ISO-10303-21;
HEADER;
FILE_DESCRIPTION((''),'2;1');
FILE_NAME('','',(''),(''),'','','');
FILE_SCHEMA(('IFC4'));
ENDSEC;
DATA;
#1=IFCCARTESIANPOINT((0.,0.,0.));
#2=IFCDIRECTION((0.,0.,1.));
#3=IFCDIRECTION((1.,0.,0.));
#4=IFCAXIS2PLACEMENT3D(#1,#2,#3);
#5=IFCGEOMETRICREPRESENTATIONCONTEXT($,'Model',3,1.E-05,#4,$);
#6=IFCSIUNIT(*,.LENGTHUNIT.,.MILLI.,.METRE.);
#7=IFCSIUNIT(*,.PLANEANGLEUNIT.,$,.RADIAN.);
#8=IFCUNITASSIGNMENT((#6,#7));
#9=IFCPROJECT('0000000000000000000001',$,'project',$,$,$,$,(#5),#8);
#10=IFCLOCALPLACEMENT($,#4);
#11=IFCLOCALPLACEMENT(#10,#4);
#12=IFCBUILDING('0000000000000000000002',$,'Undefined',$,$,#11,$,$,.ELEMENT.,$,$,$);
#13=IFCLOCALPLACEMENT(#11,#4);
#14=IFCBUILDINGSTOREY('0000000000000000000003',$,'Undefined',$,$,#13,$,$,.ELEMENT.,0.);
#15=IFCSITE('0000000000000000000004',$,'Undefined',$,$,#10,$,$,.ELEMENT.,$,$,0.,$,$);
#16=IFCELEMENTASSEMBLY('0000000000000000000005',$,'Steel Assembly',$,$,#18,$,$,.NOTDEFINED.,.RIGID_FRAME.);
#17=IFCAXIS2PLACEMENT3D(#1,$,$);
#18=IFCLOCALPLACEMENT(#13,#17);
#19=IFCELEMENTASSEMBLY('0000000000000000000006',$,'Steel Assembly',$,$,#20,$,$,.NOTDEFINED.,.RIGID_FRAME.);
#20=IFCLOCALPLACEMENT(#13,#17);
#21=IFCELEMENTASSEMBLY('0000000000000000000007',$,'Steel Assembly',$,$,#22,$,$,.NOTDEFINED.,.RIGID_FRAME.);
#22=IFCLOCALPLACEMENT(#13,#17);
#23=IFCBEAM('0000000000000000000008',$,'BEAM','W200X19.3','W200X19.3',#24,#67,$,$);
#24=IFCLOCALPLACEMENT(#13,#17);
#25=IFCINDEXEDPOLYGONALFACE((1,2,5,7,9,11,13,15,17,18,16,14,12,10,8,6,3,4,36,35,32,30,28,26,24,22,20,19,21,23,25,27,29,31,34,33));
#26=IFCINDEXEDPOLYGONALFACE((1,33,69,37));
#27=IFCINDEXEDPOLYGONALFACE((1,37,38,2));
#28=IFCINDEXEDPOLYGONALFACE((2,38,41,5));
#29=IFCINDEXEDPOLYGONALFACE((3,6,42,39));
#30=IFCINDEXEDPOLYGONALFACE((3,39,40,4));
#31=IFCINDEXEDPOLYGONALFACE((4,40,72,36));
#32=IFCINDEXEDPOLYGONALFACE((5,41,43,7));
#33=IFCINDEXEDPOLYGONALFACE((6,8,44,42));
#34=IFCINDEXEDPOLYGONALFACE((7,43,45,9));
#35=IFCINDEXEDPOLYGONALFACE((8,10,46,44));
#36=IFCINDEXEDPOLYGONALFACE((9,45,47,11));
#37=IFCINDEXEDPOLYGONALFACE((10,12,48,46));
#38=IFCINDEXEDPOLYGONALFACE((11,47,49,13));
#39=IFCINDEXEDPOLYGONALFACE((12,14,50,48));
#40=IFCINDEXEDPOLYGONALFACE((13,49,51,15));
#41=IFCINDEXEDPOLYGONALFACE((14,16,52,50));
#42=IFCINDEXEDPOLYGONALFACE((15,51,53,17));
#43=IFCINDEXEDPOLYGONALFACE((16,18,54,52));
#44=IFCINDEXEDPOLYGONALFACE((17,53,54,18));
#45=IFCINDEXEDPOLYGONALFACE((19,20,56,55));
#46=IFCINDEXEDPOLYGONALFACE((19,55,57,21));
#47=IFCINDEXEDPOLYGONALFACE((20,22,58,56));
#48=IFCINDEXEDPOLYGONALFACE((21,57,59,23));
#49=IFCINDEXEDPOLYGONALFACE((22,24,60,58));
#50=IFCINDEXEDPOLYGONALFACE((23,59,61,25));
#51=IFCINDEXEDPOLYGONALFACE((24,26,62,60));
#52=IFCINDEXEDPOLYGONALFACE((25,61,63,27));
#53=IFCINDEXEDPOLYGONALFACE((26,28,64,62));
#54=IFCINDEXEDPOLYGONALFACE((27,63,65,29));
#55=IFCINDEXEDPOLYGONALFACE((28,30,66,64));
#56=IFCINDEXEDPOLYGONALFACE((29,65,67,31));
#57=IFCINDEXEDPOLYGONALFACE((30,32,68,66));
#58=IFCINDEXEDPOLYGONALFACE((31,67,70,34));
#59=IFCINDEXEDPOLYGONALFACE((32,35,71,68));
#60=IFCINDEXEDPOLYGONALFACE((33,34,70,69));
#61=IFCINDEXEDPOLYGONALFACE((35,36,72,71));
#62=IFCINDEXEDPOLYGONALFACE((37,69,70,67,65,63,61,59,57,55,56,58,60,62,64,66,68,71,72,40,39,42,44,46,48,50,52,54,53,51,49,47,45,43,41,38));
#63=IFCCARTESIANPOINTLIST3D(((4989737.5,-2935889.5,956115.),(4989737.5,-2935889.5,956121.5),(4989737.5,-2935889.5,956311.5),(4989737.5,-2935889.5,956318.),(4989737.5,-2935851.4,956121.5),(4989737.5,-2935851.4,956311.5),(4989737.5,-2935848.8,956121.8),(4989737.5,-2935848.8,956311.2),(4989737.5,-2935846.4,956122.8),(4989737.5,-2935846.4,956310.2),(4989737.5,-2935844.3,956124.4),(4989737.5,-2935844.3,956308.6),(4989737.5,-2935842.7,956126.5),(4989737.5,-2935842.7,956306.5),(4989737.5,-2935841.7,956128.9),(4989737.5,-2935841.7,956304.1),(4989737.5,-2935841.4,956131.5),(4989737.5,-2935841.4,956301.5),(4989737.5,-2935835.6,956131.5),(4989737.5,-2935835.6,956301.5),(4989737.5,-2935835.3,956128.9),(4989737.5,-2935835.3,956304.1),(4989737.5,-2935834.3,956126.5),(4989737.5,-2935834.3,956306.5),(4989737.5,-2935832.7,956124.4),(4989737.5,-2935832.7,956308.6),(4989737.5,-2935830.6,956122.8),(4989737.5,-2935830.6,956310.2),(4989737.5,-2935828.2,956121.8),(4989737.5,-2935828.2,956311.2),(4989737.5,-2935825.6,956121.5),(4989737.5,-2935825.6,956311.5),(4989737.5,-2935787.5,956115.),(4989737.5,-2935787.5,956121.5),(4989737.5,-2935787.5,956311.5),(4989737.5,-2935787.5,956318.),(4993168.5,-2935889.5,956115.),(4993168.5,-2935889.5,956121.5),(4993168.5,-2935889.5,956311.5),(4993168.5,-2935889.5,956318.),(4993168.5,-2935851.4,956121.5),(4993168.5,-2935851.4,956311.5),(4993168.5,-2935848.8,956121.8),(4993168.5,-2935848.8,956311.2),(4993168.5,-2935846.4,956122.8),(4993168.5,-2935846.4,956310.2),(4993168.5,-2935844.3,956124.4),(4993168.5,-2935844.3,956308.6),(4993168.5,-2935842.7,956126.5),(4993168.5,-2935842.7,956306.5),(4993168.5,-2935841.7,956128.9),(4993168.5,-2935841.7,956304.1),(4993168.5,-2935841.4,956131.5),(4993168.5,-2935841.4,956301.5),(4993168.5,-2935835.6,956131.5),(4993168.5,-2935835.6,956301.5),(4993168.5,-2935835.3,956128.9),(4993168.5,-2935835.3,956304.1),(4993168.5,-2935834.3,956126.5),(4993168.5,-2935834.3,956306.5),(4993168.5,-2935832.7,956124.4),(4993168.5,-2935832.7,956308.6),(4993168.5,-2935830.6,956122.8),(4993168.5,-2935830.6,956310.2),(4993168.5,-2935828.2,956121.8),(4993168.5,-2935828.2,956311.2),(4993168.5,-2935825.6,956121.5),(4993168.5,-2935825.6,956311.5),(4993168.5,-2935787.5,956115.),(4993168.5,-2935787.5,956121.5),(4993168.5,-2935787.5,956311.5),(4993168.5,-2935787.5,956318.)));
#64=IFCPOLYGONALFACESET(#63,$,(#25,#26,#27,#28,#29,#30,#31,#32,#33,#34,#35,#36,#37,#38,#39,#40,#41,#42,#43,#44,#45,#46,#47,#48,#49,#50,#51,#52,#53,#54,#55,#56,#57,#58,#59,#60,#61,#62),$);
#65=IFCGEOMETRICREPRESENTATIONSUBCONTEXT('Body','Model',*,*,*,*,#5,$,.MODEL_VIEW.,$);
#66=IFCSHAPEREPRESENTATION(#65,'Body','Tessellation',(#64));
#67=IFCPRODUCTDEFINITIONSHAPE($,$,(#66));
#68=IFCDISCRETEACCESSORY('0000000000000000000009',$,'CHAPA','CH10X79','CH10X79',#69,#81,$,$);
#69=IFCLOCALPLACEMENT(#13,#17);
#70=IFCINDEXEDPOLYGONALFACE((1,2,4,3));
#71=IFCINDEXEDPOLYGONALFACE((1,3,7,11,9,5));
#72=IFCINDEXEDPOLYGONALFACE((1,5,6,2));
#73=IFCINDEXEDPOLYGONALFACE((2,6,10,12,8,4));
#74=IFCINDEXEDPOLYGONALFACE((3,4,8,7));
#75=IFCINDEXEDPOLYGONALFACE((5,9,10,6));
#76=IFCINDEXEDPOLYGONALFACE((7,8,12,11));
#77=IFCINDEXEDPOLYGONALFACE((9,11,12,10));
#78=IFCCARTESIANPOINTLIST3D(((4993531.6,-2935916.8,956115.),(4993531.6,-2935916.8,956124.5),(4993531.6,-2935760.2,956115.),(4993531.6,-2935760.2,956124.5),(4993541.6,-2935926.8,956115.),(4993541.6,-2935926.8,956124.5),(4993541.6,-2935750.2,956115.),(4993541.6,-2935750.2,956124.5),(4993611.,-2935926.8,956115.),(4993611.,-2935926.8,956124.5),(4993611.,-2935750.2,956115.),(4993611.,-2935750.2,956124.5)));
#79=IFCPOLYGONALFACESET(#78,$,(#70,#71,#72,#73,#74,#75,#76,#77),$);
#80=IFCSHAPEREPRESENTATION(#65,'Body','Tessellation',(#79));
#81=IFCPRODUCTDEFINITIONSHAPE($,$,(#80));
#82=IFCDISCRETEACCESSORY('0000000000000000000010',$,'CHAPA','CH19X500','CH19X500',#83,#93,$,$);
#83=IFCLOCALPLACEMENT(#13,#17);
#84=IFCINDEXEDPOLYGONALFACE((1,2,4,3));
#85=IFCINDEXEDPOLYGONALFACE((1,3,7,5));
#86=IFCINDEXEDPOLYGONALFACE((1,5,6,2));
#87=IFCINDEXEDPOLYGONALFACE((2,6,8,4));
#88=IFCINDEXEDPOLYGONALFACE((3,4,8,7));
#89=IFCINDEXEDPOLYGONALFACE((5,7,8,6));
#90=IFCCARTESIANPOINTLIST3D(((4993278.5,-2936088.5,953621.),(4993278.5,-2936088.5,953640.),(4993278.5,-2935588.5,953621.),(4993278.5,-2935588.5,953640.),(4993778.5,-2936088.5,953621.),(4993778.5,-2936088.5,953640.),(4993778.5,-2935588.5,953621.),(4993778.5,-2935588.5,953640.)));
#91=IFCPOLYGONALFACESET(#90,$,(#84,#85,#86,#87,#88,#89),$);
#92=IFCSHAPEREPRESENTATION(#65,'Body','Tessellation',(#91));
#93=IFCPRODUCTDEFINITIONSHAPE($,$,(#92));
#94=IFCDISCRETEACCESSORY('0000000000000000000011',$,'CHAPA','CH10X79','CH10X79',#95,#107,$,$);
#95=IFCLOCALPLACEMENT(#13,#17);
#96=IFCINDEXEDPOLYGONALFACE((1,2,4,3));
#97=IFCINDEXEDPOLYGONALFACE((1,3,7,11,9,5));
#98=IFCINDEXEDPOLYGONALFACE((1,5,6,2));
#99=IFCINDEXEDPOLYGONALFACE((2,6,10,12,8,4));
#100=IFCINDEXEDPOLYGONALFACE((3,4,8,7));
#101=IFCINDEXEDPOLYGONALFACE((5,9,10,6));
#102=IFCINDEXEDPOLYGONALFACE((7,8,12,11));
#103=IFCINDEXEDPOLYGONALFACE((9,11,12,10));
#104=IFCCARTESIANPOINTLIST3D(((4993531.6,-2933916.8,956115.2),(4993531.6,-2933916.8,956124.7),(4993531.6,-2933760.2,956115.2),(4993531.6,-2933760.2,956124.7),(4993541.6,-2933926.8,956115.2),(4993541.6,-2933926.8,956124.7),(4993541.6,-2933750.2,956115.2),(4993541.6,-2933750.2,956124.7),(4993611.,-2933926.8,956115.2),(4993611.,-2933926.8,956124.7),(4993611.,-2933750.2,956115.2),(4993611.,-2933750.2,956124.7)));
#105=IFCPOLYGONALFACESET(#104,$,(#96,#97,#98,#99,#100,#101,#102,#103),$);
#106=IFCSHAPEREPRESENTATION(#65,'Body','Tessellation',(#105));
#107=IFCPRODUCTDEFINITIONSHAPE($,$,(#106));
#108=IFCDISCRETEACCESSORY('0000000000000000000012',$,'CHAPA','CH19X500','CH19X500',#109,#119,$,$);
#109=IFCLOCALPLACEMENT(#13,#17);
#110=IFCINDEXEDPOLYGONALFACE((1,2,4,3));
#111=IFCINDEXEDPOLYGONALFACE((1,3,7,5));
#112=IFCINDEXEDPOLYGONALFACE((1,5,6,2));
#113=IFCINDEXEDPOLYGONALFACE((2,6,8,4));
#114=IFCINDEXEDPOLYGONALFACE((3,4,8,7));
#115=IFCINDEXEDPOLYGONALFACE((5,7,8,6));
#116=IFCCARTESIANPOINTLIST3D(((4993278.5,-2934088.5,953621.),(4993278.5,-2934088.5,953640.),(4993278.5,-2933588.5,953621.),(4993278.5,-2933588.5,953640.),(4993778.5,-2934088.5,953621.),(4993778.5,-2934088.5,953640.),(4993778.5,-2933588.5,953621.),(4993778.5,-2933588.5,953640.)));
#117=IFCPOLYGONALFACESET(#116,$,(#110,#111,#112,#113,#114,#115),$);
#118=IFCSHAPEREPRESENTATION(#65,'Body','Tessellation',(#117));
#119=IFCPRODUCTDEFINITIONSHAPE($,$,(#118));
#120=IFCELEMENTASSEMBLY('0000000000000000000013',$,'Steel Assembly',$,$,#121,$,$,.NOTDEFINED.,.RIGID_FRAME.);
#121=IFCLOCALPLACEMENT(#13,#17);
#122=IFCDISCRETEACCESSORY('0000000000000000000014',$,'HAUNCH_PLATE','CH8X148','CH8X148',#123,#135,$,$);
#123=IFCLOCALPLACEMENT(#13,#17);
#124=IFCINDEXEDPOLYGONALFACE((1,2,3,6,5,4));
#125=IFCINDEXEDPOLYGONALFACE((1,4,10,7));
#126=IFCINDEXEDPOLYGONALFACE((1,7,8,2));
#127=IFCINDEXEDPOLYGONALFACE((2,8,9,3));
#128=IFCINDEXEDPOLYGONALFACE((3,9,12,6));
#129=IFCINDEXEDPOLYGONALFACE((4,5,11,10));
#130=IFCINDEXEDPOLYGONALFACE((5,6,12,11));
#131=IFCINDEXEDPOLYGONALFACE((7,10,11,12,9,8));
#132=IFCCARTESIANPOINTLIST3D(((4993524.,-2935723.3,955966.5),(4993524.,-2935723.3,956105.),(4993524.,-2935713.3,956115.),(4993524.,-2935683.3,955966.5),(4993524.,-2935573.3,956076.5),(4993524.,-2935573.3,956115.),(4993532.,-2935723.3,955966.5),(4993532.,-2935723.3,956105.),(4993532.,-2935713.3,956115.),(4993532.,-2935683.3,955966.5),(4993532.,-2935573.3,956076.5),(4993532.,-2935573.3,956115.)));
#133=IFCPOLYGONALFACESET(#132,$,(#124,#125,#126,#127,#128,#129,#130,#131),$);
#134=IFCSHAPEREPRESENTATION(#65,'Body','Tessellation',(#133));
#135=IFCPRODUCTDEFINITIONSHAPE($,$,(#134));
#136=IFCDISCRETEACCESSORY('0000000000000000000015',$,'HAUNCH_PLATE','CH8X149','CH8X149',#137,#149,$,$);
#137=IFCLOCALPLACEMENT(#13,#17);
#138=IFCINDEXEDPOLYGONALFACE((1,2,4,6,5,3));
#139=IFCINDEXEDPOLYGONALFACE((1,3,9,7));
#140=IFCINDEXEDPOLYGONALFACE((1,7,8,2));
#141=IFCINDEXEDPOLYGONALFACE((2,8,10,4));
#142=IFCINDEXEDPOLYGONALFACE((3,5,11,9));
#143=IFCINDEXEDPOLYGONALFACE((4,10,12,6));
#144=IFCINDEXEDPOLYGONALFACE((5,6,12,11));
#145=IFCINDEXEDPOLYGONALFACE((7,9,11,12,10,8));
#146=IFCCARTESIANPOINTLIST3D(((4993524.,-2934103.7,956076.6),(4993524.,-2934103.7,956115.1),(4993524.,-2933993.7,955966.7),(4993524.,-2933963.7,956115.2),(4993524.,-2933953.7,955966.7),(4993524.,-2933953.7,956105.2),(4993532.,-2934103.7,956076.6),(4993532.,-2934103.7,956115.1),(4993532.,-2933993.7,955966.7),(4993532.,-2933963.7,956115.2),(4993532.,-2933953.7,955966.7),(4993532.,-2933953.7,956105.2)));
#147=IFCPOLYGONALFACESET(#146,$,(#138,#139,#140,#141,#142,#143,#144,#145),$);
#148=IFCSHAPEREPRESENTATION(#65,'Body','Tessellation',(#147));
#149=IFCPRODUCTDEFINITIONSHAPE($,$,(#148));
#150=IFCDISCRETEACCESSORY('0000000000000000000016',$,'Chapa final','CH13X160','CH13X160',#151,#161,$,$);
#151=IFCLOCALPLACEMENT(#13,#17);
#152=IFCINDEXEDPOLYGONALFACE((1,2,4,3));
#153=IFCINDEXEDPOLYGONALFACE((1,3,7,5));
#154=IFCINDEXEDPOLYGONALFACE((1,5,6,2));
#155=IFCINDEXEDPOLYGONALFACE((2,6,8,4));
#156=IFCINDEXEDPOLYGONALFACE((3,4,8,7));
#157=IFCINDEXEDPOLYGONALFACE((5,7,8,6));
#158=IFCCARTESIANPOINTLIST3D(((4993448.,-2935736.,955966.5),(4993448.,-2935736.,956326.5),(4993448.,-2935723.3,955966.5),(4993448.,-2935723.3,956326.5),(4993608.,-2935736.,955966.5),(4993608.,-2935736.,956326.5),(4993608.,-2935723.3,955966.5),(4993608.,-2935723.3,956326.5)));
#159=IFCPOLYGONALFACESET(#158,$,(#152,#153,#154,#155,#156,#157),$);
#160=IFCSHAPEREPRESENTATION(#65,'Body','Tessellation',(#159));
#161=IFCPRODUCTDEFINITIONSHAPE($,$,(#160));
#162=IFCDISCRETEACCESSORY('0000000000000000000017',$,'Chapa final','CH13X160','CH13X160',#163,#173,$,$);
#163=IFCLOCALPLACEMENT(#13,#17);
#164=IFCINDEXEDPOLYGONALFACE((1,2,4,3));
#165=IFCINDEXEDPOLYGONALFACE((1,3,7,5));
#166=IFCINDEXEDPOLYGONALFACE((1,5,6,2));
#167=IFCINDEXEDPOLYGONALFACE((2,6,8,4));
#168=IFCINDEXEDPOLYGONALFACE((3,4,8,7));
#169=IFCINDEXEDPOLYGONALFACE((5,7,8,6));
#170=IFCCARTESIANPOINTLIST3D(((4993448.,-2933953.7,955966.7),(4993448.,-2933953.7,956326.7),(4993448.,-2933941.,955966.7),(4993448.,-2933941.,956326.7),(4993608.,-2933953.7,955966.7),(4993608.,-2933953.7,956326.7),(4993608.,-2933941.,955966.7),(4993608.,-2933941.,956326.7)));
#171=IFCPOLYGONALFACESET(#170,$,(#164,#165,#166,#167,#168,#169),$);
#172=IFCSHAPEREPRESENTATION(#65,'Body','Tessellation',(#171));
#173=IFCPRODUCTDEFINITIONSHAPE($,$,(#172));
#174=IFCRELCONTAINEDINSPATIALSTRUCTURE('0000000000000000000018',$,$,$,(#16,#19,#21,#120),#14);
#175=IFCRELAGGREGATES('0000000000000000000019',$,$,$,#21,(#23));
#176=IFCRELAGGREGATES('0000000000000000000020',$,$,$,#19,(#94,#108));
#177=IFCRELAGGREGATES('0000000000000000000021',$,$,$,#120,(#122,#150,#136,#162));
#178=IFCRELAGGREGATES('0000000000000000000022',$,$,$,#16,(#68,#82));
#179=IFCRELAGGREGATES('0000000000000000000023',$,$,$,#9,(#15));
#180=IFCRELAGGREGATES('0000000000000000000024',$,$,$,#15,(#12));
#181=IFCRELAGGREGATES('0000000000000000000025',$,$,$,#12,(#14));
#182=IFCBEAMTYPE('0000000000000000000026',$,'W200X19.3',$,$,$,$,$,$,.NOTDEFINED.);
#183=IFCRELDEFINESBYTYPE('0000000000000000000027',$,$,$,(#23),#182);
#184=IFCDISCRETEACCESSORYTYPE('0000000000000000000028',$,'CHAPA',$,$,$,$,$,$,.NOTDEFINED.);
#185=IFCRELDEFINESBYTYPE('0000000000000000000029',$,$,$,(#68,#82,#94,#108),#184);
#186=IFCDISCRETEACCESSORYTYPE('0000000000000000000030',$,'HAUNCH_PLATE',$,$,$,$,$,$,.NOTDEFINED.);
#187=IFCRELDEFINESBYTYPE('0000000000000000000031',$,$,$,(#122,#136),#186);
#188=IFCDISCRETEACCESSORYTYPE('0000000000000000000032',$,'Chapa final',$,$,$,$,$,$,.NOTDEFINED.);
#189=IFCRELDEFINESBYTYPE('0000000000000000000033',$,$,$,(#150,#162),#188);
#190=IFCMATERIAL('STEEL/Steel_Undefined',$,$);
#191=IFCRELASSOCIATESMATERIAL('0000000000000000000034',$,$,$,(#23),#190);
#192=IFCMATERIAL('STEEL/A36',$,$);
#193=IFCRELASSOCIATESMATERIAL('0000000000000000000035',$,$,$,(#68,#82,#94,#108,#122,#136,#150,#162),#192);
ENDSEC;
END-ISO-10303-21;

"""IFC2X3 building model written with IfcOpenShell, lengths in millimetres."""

from ifc_helpers import new_model, si_unit, frame, origin_with_axes, origin_2d_with_axis, place, context, subcontext, project, spatial, polyline, i_section, outline, extrude, clip, halfspace, material, type_object, element, aggregate, save


model = new_model("IFC2X3")

# Units and contexts
model_context = context("Model", 3, precision=1e-05, world=origin_with_axes())
body_context = subcontext(model_context, "Body", "Model", "MODEL_VIEW")
ifc_project = project(units=[si_unit("LENGTHUNIT", "METRE", prefix="MILLI"), si_unit("PLANEANGLEUNIT", "RADIAN")], contexts=[model_context])

# Site, building, storey
site_placement = place(None, origin_with_axes())
site = spatial("IfcSite", under=ifc_project, at=site_placement, Name="Undefined", CompositionType="ELEMENT", RefElevation=0.0)
building_placement = place(site_placement, origin_with_axes())
building = spatial("IfcBuilding", under=site, at=building_placement, Name="Undefined", CompositionType="ELEMENT")
storey_placement = place(building_placement, origin_with_axes())
storey = spatial("IfcBuildingStorey", under=building, at=storey_placement, Name="Undefined", CompositionType="ELEMENT", Elevation=0.0)

# Element assemblies
assembly_1_placement = place(storey_placement, origin_with_axes())
assembly_1 = element("IfcElementAssembly", 1, at=assembly_1_placement, inside=storey, Name="Steel Assembly", AssemblyPlace="NOTDEFINED", PredefinedType="RIGID_FRAME")
assembly_2_placement = place(storey_placement, origin_with_axes())
assembly_2 = element("IfcElementAssembly", 2, at=assembly_2_placement, inside=storey, Name="Steel Assembly", AssemblyPlace="NOTDEFINED", PredefinedType="RIGID_FRAME")

# Element assembly, beam
assembly_3_placement = place(storey_placement, origin_with_axes())
assembly_3 = element("IfcElementAssembly", 3, at=assembly_3_placement, inside=storey, Name="Steel Assembly", AssemblyPlace="NOTDEFINED", PredefinedType="RIGID_FRAME")
ifc_material_1 = material(Name="STEEL/Steel_Undefined")
beam_type = type_object("IfcBeamType", Name="W200X19.3", PredefinedType="NOTDEFINED")
beam_placement = place(assembly_3_placement, frame((4993179.0, -2935838.5, 956216.5), z_axis=(0.0, 0.0, -1.0), x_axis=(-1.0, 0.0, 0.0)))
beam = element("IfcBeam", 4, at=beam_placement, type_object=beam_type, material=ifc_material_1, Name="BEAM", Description="W200X19.3", ObjectType="W200X19.3", context=body_context, shape_type="Clipping", body=[
    clip(clip(extrude(i_section(OverallWidth=102.0, OverallDepth=203.0, WebThickness=5.8, FlangeThickness=6.5, FilletRadius=10.0, at=origin_2d_with_axis()), frame((3441.5, 0.0, 0.0), z_axis=(-1.0, 0.0, 0.0), x_axis=(0.0, -1.0, 0.0)), (0.0, 0.0, 1.0), 3431.0), halfspace(frame((3441.5, 0.0, -101.5), z_axis=(-1.0, 0.0, 0.0), x_axis=(0.0, 1.0, 0.0)), True)), halfspace(frame((10.5, 0.0, -101.5), z_axis=(1.0, 0.0, 0.0), x_axis=(0.0, -1.0, 0.0)), True)),
])
aggregate(assembly_3, [beam])

# Discrete accessories
ifc_material_2 = material(Name="STEEL/A36")
discrete_accessory_type_1 = type_object("IfcDiscreteAccessoryType", Name="CHAPA")
discrete_accessory_1_placement = place(assembly_1_placement, frame((4993531.6, -2935750.2, 956119.8), z_axis=(0.0, 0.0, -1.0), x_axis=(1.0, 0.0, 0.0)))
discrete_accessory_1 = element("IfcDiscreteAccessory", 5, at=discrete_accessory_1_placement, type_object=discrete_accessory_type_1, material=ifc_material_2, Name="CHAPA", Description="CH10X79", ObjectType="CH10X79", context=body_context, shape_type="SweptSolid", body=[
    extrude(outline(polyline([(0.0, 10.0), (10.0, 0.0), (79.4, 0.0), (79.4, 176.6), (10.0, 176.6), (0.0, 166.6), (0.0, 10.0)])), frame((0.0, 0.0, -4.8), z_axis=(0.0, 0.0, 1.0), x_axis=(1.0, 0.0, 0.0)), (0.0, 0.0, 1.0), 9.5),
])
discrete_accessory_2_placement = place(assembly_1_placement, frame((4993528.5, -2935588.5, 953630.5), z_axis=(0.0, 0.0, 1.0), x_axis=(0.0, -1.0, 0.0)))
discrete_accessory_2 = element("IfcDiscreteAccessory", 6, at=discrete_accessory_2_placement, type_object=discrete_accessory_type_1, material=ifc_material_2, Name="CHAPA", Description="CH19X500", ObjectType="CH19X500", context=body_context, shape_type="SweptSolid", body=[
    extrude(outline(polyline([(500.0, -250.0), (0.0, -250.0), (0.0, 250.0), (500.0, 250.0), (500.0, -250.0)])), frame((0.0, 0.0, -9.5), z_axis=(0.0, 0.0, 1.0), x_axis=(1.0, 0.0, 0.0)), (0.0, 0.0, 1.0), 19.0),
])
discrete_accessory_3_placement = place(assembly_2_placement, frame((4993611.0, -2933926.8, 956119.9), z_axis=(0.0, 0.0, -1.0), x_axis=(-1.0, 0.0, 0.0)))
discrete_accessory_3 = element("IfcDiscreteAccessory", 7, at=discrete_accessory_3_placement, type_object=discrete_accessory_type_1, material=ifc_material_2, Name="CHAPA", Description="CH10X79", ObjectType="CH10X79", context=body_context, shape_type="SweptSolid", body=[
    extrude(outline(polyline([(0.0, 0.0), (69.4, 0.0), (79.4, 10.0), (79.4, 166.6), (69.4, 176.6), (0.0, 176.6), (0.0, 0.0)])), frame((0.0, 0.0, -4.8), z_axis=(0.0, 0.0, 1.0), x_axis=(1.0, 0.0, 0.0)), (0.0, 0.0, 1.0), 9.5),
])
discrete_accessory_4_placement = place(assembly_2_placement, frame((4993528.5, -2933588.5, 953630.5), z_axis=(0.0, 0.0, 1.0), x_axis=(0.0, -1.0, 0.0)))
discrete_accessory_4 = element("IfcDiscreteAccessory", 8, at=discrete_accessory_4_placement, type_object=discrete_accessory_type_1, material=ifc_material_2, Name="CHAPA", Description="CH19X500", ObjectType="CH19X500", context=body_context, shape_type="SweptSolid", body=[
    extrude(outline(polyline([(500.0, -250.0), (0.0, -250.0), (0.0, 250.0), (500.0, 250.0), (500.0, -250.0)])), frame((0.0, 0.0, -9.5), z_axis=(0.0, 0.0, 1.0), x_axis=(1.0, 0.0, 0.0)), (0.0, 0.0, 1.0), 19.0),
])
aggregate(assembly_2, [discrete_accessory_3, discrete_accessory_4])

# Element assembly, discrete accessories
assembly_4_placement = place(storey_placement, origin_with_axes())
assembly_4 = element("IfcElementAssembly", 9, at=assembly_4_placement, inside=storey, Name="Steel Assembly", AssemblyPlace="NOTDEFINED", PredefinedType="RIGID_FRAME")
discrete_accessory_type_2 = type_object("IfcDiscreteAccessoryType", Name="HAUNCH_PLATE")
discrete_accessory_5_placement = place(assembly_4_placement, frame((4993528.0, -2935723.3, 956115.0), z_axis=(1.0, 0.0, 0.0), x_axis=(0.0, 0.0, -1.0)))
discrete_accessory_5 = element("IfcDiscreteAccessory", 10, at=discrete_accessory_5_placement, type_object=discrete_accessory_type_2, material=ifc_material_2, Name="HAUNCH_PLATE", Description="CH8X148", ObjectType="CH8X148", context=body_context, shape_type="SweptSolid", body=[
    extrude(outline(polyline([(0.0, 10.0), (10.0, 0.0), (148.5, 0.0), (148.5, 40.0), (38.5, 150.0), (0.0, 150.0), (0.0, 10.0)])), frame((0.0, 0.0, -4.0), z_axis=(0.0, 0.0, 1.0), x_axis=(1.0, 0.0, 0.0)), (0.0, 0.0, 1.0), 8.0),
])
discrete_accessory_6_placement = place(assembly_4_placement, frame((4993528.0, -2933953.7, 956115.2), z_axis=(-1.0, 0.0, 0.0), x_axis=(0.0, 0.0, -1.0)))
discrete_accessory_6 = element("IfcDiscreteAccessory", 11, at=discrete_accessory_6_placement, type_object=discrete_accessory_type_2, material=ifc_material_2, Name="HAUNCH_PLATE", Description="CH8X149", ObjectType="CH8X149", context=body_context, shape_type="SweptSolid", body=[
    extrude(outline(polyline([(0.0, 10.0), (10.0, 0.0), (148.5, 0.0), (148.5, 40.0), (38.5, 150.0), (0.0, 150.0), (0.0, 10.0)])), frame((0.0, 0.0, -4.0), z_axis=(0.0, 0.0, 1.0), x_axis=(1.0, 0.0, 0.0)), (0.0, 0.0, 1.0), 8.0),
])
discrete_accessory_type_3 = type_object("IfcDiscreteAccessoryType", Name="Chapa final")
discrete_accessory_7_placement = place(assembly_4_placement, frame((4993528.0, -2935729.7, 955966.5), z_axis=(0.0, 1.0, 0.0), x_axis=(0.0, 0.0, 1.0)))
discrete_accessory_7 = element("IfcDiscreteAccessory", 12, at=discrete_accessory_7_placement, type_object=discrete_accessory_type_3, material=ifc_material_2, Name="Chapa final", Description="CH13X160", ObjectType="CH13X160", context=body_context, shape_type="SweptSolid", body=[
    extrude(outline(polyline([(0.0, -80.0), (0.0, 80.0), (360.0, 80.0), (360.0, -80.0), (0.0, -80.0)])), frame((0.0, 0.0, -6.3), z_axis=(0.0, 0.0, 1.0), x_axis=(1.0, 0.0, 0.0)), (0.0, 0.0, 1.0), 12.7),
])
discrete_accessory_8_placement = place(assembly_4_placement, frame((4993528.0, -2933947.4, 955966.7), z_axis=(0.0, -1.0, 0.0), x_axis=(0.0, 0.0, 1.0)))
discrete_accessory_8 = element("IfcDiscreteAccessory", 13, at=discrete_accessory_8_placement, type_object=discrete_accessory_type_3, material=ifc_material_2, Name="Chapa final", Description="CH13X160", ObjectType="CH13X160", context=body_context, shape_type="SweptSolid", body=[
    extrude(outline(polyline([(0.0, 80.0), (360.0, 80.0), (360.0, -80.0), (0.0, -80.0), (0.0, 80.0)])), frame((0.0, 0.0, -6.3), z_axis=(0.0, 0.0, 1.0), x_axis=(1.0, 0.0, 0.0)), (0.0, 0.0, 1.0), 12.7),
])
aggregate(assembly_4, [discrete_accessory_5, discrete_accessory_7, discrete_accessory_6, discrete_accessory_8])

aggregate(assembly_1, [discrete_accessory_1, discrete_accessory_2])

save(model, "model.ifc")
